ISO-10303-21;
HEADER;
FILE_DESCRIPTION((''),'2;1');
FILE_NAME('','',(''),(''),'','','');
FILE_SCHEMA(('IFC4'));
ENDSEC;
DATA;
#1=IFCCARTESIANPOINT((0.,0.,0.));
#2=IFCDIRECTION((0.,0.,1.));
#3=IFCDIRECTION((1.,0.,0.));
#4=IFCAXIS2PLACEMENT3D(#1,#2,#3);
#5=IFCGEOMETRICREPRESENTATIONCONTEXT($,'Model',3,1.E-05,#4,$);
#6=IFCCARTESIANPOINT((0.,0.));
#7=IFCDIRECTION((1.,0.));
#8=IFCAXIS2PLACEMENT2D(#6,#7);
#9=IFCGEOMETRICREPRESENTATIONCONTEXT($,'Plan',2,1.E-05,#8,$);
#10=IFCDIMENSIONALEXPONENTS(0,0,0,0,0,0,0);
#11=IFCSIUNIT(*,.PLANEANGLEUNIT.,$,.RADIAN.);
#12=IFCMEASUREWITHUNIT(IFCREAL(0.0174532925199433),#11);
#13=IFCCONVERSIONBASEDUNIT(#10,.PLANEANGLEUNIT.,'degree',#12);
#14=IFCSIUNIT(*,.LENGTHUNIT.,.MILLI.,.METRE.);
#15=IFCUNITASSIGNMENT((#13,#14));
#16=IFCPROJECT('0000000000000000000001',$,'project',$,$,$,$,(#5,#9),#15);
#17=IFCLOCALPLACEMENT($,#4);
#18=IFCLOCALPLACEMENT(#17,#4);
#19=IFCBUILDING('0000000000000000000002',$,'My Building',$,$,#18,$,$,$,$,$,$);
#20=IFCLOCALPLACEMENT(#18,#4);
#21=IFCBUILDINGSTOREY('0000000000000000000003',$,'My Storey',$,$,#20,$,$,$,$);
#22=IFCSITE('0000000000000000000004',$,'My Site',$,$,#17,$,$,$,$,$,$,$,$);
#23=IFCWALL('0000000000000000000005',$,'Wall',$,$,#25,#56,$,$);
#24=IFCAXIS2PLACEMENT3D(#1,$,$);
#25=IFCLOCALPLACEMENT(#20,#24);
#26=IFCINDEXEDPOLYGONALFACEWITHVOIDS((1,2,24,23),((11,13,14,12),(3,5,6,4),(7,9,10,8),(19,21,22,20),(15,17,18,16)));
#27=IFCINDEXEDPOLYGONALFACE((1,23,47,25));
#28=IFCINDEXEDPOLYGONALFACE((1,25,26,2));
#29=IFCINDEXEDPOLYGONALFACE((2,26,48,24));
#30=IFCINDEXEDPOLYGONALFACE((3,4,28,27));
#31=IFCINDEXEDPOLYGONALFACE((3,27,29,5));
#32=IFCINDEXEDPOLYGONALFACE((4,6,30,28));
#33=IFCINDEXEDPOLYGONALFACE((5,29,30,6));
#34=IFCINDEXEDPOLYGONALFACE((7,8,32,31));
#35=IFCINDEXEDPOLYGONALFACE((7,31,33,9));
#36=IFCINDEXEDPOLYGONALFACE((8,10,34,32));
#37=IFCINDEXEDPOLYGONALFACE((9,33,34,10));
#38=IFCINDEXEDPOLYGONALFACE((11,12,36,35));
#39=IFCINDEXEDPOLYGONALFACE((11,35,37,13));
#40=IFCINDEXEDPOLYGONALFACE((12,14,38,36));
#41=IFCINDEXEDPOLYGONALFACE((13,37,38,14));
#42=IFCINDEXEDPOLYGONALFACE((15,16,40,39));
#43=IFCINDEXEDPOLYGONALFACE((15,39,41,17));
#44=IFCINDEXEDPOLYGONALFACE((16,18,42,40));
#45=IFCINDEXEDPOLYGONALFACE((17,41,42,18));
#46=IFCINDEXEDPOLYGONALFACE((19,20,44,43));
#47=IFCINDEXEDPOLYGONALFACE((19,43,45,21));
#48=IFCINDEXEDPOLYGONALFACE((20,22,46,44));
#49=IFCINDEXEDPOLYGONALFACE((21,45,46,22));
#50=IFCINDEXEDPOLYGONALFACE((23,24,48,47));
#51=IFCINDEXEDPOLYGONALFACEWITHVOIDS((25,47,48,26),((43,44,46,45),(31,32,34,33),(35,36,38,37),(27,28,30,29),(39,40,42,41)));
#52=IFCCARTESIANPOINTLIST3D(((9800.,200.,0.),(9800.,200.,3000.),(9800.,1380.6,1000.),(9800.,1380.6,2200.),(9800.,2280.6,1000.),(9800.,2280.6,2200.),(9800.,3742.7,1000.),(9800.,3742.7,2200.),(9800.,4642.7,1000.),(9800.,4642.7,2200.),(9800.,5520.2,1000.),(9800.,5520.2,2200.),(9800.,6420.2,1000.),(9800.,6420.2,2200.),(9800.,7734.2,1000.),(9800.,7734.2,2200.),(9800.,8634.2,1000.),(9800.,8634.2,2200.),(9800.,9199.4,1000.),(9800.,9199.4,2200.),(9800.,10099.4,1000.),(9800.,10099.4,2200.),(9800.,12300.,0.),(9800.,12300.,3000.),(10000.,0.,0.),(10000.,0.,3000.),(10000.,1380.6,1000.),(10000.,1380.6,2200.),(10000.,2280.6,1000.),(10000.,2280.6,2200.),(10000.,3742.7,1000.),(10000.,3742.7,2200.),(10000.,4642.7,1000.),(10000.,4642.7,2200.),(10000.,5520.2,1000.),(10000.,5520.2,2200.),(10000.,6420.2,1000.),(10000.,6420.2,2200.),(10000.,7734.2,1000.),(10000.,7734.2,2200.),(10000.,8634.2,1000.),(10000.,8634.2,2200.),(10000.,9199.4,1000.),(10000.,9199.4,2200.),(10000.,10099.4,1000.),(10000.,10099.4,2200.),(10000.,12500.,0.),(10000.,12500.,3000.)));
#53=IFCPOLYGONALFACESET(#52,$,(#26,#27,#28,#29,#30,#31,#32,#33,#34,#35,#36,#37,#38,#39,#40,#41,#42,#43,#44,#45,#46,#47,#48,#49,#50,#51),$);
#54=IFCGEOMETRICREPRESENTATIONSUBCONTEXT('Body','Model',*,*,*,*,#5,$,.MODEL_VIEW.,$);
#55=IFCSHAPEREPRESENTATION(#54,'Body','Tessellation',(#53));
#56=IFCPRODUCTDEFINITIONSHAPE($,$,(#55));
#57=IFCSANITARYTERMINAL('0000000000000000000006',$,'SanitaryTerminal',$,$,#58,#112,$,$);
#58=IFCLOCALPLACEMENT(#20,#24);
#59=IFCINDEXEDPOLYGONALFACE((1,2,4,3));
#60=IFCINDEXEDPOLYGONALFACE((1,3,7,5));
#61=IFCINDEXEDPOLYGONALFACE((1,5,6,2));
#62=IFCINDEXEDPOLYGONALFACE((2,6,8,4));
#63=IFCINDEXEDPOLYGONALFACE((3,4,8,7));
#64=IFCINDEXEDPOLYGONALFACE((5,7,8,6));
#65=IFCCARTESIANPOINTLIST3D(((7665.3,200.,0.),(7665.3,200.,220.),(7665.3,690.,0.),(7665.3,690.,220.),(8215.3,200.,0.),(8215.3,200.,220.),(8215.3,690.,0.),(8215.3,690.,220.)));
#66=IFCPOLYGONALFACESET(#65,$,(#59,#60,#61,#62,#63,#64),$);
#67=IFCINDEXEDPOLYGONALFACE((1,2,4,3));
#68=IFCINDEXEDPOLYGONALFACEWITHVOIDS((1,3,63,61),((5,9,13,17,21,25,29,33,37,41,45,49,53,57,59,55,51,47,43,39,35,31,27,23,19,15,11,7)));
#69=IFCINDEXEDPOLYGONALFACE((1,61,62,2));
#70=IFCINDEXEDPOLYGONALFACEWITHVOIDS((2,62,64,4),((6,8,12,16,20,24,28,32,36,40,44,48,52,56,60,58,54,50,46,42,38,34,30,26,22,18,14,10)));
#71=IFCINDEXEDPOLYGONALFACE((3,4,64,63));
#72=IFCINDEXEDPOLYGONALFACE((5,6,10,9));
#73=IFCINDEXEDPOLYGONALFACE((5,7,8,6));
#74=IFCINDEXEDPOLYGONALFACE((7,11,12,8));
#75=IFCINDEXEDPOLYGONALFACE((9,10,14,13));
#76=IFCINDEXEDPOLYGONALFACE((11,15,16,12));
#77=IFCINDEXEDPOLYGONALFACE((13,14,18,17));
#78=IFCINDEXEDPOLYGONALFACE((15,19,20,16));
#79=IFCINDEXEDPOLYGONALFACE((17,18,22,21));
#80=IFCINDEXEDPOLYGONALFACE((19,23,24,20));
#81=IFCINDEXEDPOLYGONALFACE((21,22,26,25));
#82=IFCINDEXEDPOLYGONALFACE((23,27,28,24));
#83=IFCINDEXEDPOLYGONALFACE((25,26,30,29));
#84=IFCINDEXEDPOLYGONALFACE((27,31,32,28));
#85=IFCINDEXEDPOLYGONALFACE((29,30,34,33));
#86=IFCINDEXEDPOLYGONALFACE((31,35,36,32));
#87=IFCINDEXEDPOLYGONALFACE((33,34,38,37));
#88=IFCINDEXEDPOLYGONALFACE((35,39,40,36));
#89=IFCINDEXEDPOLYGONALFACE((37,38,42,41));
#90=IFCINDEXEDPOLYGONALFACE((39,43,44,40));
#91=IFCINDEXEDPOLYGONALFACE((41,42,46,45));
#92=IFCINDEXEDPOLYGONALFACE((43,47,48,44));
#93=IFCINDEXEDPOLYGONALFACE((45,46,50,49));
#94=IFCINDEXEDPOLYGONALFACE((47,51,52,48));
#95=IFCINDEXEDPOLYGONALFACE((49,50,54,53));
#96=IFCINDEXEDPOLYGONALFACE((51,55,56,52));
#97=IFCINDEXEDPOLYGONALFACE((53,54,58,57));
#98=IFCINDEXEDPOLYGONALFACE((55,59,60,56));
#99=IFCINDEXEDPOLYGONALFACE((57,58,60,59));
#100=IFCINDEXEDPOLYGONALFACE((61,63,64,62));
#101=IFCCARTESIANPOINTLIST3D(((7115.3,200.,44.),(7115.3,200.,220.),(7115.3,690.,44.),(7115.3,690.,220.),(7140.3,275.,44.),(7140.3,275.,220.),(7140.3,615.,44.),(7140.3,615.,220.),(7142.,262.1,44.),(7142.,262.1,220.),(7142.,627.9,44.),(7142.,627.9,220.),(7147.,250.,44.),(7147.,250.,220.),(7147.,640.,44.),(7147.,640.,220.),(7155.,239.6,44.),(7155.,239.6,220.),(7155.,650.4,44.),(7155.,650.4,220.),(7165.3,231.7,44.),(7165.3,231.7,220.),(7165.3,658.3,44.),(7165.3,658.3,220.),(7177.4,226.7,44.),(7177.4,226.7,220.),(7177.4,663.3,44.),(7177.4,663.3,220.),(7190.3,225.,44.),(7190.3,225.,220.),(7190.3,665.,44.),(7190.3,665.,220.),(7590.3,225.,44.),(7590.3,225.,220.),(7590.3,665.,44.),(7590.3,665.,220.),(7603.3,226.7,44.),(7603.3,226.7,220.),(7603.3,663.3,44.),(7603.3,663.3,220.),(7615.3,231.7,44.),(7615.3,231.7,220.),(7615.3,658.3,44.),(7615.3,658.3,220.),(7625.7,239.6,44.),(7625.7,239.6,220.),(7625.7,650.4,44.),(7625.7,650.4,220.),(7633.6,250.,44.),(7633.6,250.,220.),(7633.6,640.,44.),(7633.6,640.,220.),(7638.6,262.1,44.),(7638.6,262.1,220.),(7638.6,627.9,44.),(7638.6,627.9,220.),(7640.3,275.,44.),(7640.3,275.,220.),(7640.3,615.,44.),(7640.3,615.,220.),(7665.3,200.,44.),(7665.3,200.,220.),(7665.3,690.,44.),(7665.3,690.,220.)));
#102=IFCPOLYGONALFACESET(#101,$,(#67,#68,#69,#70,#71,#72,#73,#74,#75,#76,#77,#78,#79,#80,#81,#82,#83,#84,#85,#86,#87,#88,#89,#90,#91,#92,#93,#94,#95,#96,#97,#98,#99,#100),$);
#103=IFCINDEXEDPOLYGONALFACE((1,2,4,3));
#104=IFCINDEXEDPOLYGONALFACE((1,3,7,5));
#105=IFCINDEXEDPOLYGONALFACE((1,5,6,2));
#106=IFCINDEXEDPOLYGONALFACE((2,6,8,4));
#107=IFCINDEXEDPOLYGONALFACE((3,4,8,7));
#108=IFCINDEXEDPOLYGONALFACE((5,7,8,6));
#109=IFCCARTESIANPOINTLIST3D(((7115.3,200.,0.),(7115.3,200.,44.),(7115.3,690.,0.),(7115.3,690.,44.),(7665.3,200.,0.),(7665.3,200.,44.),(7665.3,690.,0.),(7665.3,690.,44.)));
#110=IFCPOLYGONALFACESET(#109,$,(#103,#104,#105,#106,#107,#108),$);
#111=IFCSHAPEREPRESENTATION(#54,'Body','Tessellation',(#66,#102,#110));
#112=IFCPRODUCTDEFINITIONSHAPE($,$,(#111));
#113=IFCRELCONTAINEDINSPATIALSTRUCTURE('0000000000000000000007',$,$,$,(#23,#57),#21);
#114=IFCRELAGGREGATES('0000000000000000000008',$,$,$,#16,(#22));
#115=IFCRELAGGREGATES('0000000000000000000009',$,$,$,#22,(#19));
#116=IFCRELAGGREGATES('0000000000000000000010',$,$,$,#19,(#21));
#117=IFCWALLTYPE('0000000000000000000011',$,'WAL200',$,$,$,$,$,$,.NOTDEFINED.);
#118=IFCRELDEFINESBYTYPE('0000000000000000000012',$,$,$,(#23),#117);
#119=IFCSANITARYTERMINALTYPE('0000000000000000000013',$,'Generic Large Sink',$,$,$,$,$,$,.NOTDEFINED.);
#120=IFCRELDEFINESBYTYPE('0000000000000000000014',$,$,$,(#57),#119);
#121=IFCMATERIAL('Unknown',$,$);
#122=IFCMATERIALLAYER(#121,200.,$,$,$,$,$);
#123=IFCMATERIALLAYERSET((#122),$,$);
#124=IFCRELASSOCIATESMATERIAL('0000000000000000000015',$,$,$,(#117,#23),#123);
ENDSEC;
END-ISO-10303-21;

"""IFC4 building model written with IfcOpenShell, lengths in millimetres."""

from ifc_helpers import new_model, entity, si_unit, converted_unit, frame, origin_with_axes, origin_2d_with_axis, place, context, subcontext, project, spatial, line, indexed_curve, outline, extrude, clip, halfspace, shape, source, transform, mapped, material, layer, layer_set, layer_usage, type_object, type_shapes, element, save


model = new_model("IFC4")

# Units and contexts
model_context = context("Model", 3, precision=1e-05, world=origin_with_axes())
plan_context = context("Plan", 2, precision=1e-05, world=origin_2d_with_axis())
body_context_1 = subcontext(model_context, "Body", "Model", "MODEL_VIEW")
body_context_2 = subcontext(plan_context, "Body", "Plan", "PLAN_VIEW")
ifc_project = project(units=[converted_unit("PLANEANGLEUNIT", "degree", entity("IfcReal", 0.0174532925199433), si_unit("PLANEANGLEUNIT", "RADIAN"), dimensions=[0, 0, 0, 0, 0, 0, 0]), si_unit("LENGTHUNIT", "METRE", prefix="MILLI")], contexts=[model_context, plan_context])

# Site, building, storey
site_placement = place(None, origin_with_axes())
site = spatial("IfcSite", under=ifc_project, at=site_placement, Name="My Site")
building_placement = place(site_placement, origin_with_axes())
building = spatial("IfcBuilding", under=site, at=building_placement, Name="My Building")
storey_placement = place(building_placement, origin_with_axes())
storey = spatial("IfcBuildingStorey", under=building, at=storey_placement, Name="My Storey")

# Shared definitions
ifc_material = material(Name="Unknown")

# Shared definitions
ifc_layer_1 = layer(ifc_material, 200.0)
ifc_layer_set_1 = layer_set([ifc_layer_1])
wall_type_1 = type_object("IfcWallType", Name="WAL200", PredefinedType="NOTDEFINED", material=ifc_layer_set_1)
shared_shape_1 = source(origin_with_axes(), body_context_1, "Body", "SolidModel", [
    extrude(outline(indexed_curve([(0.0, 0.0), (900.0, 0.0), (900.0, 1200.0), (0.0, 1200.0)], segments=[line(1, 2, 3, 4, 1)])), frame((0.0, -600.0, 0.0), z_axis=(0.0, -1.0, 0.0), x_axis=(1.0, 0.0, 0.0)), (0.0, 0.0, -1.0), 1200.0),
])

# Wall, openings
ifc_layer_usage_1 = layer_usage(ifc_layer_set_1, "AXIS2", "POSITIVE", 0.0)
wall_1_placement = place(storey_placement, frame((10000.0, 0.0, 0.0), z_axis=(0.0, 0.0, 1.0), x_axis=(0.0, 1.0, 0.0)))
wall_1 = element("IfcWall", 1, at=wall_1_placement, inside=storey, type_object=wall_type_1, material=ifc_layer_usage_1, Name="Wall", context=body_context_1, shape_type="Clipping", body=[
    clip(clip(extrude(outline(indexed_curve([(0.0, 0.0), (0.0, 200.0), (12500.0, 200.0), (12500.0, 0.0), (0.0, 0.0)], self_intersect=False)), origin_with_axes(), (0.0, 0.0, 1.0), 3000.0), halfspace(frame((12500.0, 0.0, 0.0), z_axis=(0.707106, 0.707107, 0.0), x_axis=(0.707107, -0.707107, 0.0)), False)), halfspace(frame((0.0, 0.0, 0.0), z_axis=(-0.707107, 0.707107, 0.0), x_axis=(0.707107, 0.707107, 0.0)), False)),
])
opening_1_placement = place(wall_1_placement, frame((1380.6, 0.0, 1000.0), z_axis=(0.0, 0.0, 1.0), x_axis=(1.0, 0.0, 0.0)))
element("IfcOpeningElement", 2, at=opening_1_placement, cuts=wall_1, PredefinedType="OPENING", context=body_context_1, shape_type="MappedRepresentation", body=[
    mapped(shared_shape_1, transform((0.0, 0.0, 0.0), x_axis=(1.0, 0.0, 0.0), y_axis=(0.0, 1.0, 0.0), z_axis=(0.0, 0.0, 1.0), scale=1.0)),
])
opening_2_placement = place(wall_1_placement, frame((3742.7, 0.0, 1000.0), z_axis=(0.0, 0.0, 1.0), x_axis=(1.0, 0.0, 0.0)))
element("IfcOpeningElement", 3, at=opening_2_placement, cuts=wall_1, PredefinedType="OPENING", context=body_context_1, shape_type="MappedRepresentation", body=[
    mapped(shared_shape_1, transform((0.0, 0.0, 0.0), x_axis=(1.0, 0.0, 0.0), y_axis=(0.0, 1.0, 0.0), z_axis=(0.0, 0.0, 1.0), scale=1.0)),
])
opening_3_placement = place(wall_1_placement, frame((5520.2, 0.0, 1000.0), z_axis=(0.0, 0.0, 1.0), x_axis=(1.0, 0.0, 0.0)))
element("IfcOpeningElement", 4, at=opening_3_placement, cuts=wall_1, PredefinedType="OPENING", context=body_context_1, shape_type="MappedRepresentation", body=[
    mapped(shared_shape_1, transform((0.0, 0.0, 0.0), x_axis=(1.0, 0.0, 0.0), y_axis=(0.0, 1.0, 0.0), z_axis=(0.0, 0.0, 1.0), scale=1.0)),
])
opening_4_placement = place(wall_1_placement, frame((7734.2, 0.0, 1000.0), z_axis=(0.0, 0.0, 1.0), x_axis=(1.0, 0.0, 0.0)))
element("IfcOpeningElement", 5, at=opening_4_placement, cuts=wall_1, PredefinedType="OPENING", context=body_context_1, shape_type="MappedRepresentation", body=[
    mapped(shared_shape_1, transform((0.0, 0.0, 0.0), x_axis=(1.0, 0.0, 0.0), y_axis=(0.0, 1.0, 0.0), z_axis=(0.0, 0.0, 1.0), scale=1.0)),
])
opening_5_placement = place(wall_1_placement, frame((9199.4, 0.0, 1000.0), z_axis=(0.0, 0.0, 1.0), x_axis=(1.0, 0.0, 0.0)))
element("IfcOpeningElement", 6, at=opening_5_placement, cuts=wall_1, PredefinedType="OPENING", context=body_context_1, shape_type="MappedRepresentation", body=[
    mapped(shared_shape_1, transform((0.0, 0.0, 0.0), x_axis=(1.0, 0.0, 0.0), y_axis=(0.0, 1.0, 0.0), z_axis=(0.0, 0.0, 1.0), scale=1.0)),
])

# Sanitary terminal
sanitary_terminal_type_1 = type_object("IfcSanitaryTerminalType", Name="Generic Large Sink", PredefinedType="NOTDEFINED")
shared_indexed_poly_curve_1 = entity("IfcIndexedPolyCurve", entity("IfcCartesianPointList2D", [[550.0, 0.0], [1100.0, 0.0], [1100.0, 490.0], [550.0, 490.0]]), [entity("IfcLineIndex", [1, 2, 3, 4, 1])])
shared_shape_2 = source(origin_with_axes(), body_context_1, "Body", "SweptSolid", [
    extrude(outline(indexed_curve([(0.0, 0.0), (550.0, 0.0), (550.0, 490.0), (0.0, 490.0)], segments=[line(1, 2, 3, 4, 1)])), frame((-550.0, -490.0, 0.0), z_axis=(0.0, 0.0, 1.0), x_axis=(1.0, 0.0, 0.0)), (0.0, 0.0, 1.0), 220.0),
    entity("IfcExtrudedAreaSolid", entity("IfcArbitraryProfileDefWithVoids", "AREA", None, shared_indexed_poly_curve_1, [entity("IfcIndexedPolyCurve", entity("IfcCartesianPointList2D", [[575.0, 75.0], [589.6, 39.6], [625.0, 25.0], [1025.0, 25.0], [1060.4, 39.6], [1075.0, 75.0], [1075.0, 415.0], [1060.4, 450.4], [1025.0, 465.0], [625.0, 465.0], [589.6, 450.4], [575.0, 415.0]]), [entity("IfcLineIndex", [12, 1]), entity("IfcArcIndex", [1, 2, 3]), entity("IfcLineIndex", [3, 4]), entity("IfcArcIndex", [4, 5, 6]), entity("IfcLineIndex", [6, 7]), entity("IfcArcIndex", [7, 8, 9]), entity("IfcLineIndex", [9, 10]), entity("IfcArcIndex", [10, 11, 12]), entity("IfcLineIndex", [12, 1])])]), entity("IfcAxis2Placement3D", entity("IfcCartesianPoint", [-550.0, -490.0, 44.0]), entity("IfcDirection", [0.0, 0.0, 1.0]), entity("IfcDirection", [1.0, 0.0, 0.0])), entity("IfcDirection", [0.0, 0.0, 1.0]), 176.0),
    entity("IfcExtrudedAreaSolid", entity("IfcArbitraryClosedProfileDef", "AREA", None, shared_indexed_poly_curve_1), entity("IfcAxis2Placement3D", entity("IfcCartesianPoint", [-550.0, -490.0, 0.0]), entity("IfcDirection", [0.0, 0.0, 1.0]), entity("IfcDirection", [1.0, 0.0, 0.0])), entity("IfcDirection", [0.0, 0.0, 1.0]), 44.0),
])
shared_shape_3 = source(origin_with_axes(), body_context_2, "Body", "Curve2D", [
    entity("IfcIndexedPolyCurve", entity("IfcCartesianPointList2D", [[-550.0, -490.0], [550.0, -490.0], [550.0, 0.0], [-550.0, 0.0]]), [entity("IfcLineIndex", [1, 2, 3, 4, 1])]),
    entity("IfcIndexedPolyCurve", entity("IfcCartesianPointList2D", [[25.0, -415.0], [39.6, -450.4], [75.0, -465.0], [475.0, -465.0], [510.4, -450.4], [525.0, -415.0], [525.0, -75.0], [510.4, -39.6], [475.0, -25.0], [75.0, -25.0], [39.6, -39.6], [25.0, -75.0]]), [entity("IfcLineIndex", [12, 1]), entity("IfcArcIndex", [1, 2, 3]), entity("IfcLineIndex", [3, 4]), entity("IfcArcIndex", [4, 5, 6]), entity("IfcLineIndex", [6, 7]), entity("IfcArcIndex", [7, 8, 9]), entity("IfcLineIndex", [9, 10]), entity("IfcArcIndex", [10, 11, 12]), entity("IfcLineIndex", [12, 1])]),
    entity("IfcCircle", entity("IfcAxis2Placement2D", entity("IfcCartesianPoint", [275.0, -125.0])), 25.0),
    entity("IfcIndexedPolyCurve", entity("IfcCartesianPointList2D", [[275.0, -12.5], [275.0, -132.5]])),
])
type_shapes(sanitary_terminal_type_1, [shared_shape_2, shared_shape_3])
sanitary_terminal_1_placement = place(storey_placement, frame((7665.3, 200.0, 0.0), z_axis=(0.0, 0.0, 1.0), x_axis=(-1.0, 0.0, 0.0)))
element("IfcSanitaryTerminal", 7, at=sanitary_terminal_1_placement, inside=storey, type_object=sanitary_terminal_type_1, Name="SanitaryTerminal", shapes=[
    shape(body_context_1, "Body", "MappedRepresentation", [mapped(shared_shape_2, transform((0.0, 0.0, 0.0), x_axis=(1.0, 0.0, 0.0), y_axis=(0.0, 1.0, 0.0), z_axis=(0.0, 0.0, 1.0), scale=1.0))]),
    shape(body_context_2, "Body", "MappedRepresentation", [mapped(shared_shape_3, transform((0.0, 0.0, 0.0), x_axis=(1.0, 0.0, 0.0), y_axis=(0.0, 1.0, 0.0), z_axis=(0.0, 0.0, 1.0), scale=1.0))]),
])

save(model, "model.ifc")
